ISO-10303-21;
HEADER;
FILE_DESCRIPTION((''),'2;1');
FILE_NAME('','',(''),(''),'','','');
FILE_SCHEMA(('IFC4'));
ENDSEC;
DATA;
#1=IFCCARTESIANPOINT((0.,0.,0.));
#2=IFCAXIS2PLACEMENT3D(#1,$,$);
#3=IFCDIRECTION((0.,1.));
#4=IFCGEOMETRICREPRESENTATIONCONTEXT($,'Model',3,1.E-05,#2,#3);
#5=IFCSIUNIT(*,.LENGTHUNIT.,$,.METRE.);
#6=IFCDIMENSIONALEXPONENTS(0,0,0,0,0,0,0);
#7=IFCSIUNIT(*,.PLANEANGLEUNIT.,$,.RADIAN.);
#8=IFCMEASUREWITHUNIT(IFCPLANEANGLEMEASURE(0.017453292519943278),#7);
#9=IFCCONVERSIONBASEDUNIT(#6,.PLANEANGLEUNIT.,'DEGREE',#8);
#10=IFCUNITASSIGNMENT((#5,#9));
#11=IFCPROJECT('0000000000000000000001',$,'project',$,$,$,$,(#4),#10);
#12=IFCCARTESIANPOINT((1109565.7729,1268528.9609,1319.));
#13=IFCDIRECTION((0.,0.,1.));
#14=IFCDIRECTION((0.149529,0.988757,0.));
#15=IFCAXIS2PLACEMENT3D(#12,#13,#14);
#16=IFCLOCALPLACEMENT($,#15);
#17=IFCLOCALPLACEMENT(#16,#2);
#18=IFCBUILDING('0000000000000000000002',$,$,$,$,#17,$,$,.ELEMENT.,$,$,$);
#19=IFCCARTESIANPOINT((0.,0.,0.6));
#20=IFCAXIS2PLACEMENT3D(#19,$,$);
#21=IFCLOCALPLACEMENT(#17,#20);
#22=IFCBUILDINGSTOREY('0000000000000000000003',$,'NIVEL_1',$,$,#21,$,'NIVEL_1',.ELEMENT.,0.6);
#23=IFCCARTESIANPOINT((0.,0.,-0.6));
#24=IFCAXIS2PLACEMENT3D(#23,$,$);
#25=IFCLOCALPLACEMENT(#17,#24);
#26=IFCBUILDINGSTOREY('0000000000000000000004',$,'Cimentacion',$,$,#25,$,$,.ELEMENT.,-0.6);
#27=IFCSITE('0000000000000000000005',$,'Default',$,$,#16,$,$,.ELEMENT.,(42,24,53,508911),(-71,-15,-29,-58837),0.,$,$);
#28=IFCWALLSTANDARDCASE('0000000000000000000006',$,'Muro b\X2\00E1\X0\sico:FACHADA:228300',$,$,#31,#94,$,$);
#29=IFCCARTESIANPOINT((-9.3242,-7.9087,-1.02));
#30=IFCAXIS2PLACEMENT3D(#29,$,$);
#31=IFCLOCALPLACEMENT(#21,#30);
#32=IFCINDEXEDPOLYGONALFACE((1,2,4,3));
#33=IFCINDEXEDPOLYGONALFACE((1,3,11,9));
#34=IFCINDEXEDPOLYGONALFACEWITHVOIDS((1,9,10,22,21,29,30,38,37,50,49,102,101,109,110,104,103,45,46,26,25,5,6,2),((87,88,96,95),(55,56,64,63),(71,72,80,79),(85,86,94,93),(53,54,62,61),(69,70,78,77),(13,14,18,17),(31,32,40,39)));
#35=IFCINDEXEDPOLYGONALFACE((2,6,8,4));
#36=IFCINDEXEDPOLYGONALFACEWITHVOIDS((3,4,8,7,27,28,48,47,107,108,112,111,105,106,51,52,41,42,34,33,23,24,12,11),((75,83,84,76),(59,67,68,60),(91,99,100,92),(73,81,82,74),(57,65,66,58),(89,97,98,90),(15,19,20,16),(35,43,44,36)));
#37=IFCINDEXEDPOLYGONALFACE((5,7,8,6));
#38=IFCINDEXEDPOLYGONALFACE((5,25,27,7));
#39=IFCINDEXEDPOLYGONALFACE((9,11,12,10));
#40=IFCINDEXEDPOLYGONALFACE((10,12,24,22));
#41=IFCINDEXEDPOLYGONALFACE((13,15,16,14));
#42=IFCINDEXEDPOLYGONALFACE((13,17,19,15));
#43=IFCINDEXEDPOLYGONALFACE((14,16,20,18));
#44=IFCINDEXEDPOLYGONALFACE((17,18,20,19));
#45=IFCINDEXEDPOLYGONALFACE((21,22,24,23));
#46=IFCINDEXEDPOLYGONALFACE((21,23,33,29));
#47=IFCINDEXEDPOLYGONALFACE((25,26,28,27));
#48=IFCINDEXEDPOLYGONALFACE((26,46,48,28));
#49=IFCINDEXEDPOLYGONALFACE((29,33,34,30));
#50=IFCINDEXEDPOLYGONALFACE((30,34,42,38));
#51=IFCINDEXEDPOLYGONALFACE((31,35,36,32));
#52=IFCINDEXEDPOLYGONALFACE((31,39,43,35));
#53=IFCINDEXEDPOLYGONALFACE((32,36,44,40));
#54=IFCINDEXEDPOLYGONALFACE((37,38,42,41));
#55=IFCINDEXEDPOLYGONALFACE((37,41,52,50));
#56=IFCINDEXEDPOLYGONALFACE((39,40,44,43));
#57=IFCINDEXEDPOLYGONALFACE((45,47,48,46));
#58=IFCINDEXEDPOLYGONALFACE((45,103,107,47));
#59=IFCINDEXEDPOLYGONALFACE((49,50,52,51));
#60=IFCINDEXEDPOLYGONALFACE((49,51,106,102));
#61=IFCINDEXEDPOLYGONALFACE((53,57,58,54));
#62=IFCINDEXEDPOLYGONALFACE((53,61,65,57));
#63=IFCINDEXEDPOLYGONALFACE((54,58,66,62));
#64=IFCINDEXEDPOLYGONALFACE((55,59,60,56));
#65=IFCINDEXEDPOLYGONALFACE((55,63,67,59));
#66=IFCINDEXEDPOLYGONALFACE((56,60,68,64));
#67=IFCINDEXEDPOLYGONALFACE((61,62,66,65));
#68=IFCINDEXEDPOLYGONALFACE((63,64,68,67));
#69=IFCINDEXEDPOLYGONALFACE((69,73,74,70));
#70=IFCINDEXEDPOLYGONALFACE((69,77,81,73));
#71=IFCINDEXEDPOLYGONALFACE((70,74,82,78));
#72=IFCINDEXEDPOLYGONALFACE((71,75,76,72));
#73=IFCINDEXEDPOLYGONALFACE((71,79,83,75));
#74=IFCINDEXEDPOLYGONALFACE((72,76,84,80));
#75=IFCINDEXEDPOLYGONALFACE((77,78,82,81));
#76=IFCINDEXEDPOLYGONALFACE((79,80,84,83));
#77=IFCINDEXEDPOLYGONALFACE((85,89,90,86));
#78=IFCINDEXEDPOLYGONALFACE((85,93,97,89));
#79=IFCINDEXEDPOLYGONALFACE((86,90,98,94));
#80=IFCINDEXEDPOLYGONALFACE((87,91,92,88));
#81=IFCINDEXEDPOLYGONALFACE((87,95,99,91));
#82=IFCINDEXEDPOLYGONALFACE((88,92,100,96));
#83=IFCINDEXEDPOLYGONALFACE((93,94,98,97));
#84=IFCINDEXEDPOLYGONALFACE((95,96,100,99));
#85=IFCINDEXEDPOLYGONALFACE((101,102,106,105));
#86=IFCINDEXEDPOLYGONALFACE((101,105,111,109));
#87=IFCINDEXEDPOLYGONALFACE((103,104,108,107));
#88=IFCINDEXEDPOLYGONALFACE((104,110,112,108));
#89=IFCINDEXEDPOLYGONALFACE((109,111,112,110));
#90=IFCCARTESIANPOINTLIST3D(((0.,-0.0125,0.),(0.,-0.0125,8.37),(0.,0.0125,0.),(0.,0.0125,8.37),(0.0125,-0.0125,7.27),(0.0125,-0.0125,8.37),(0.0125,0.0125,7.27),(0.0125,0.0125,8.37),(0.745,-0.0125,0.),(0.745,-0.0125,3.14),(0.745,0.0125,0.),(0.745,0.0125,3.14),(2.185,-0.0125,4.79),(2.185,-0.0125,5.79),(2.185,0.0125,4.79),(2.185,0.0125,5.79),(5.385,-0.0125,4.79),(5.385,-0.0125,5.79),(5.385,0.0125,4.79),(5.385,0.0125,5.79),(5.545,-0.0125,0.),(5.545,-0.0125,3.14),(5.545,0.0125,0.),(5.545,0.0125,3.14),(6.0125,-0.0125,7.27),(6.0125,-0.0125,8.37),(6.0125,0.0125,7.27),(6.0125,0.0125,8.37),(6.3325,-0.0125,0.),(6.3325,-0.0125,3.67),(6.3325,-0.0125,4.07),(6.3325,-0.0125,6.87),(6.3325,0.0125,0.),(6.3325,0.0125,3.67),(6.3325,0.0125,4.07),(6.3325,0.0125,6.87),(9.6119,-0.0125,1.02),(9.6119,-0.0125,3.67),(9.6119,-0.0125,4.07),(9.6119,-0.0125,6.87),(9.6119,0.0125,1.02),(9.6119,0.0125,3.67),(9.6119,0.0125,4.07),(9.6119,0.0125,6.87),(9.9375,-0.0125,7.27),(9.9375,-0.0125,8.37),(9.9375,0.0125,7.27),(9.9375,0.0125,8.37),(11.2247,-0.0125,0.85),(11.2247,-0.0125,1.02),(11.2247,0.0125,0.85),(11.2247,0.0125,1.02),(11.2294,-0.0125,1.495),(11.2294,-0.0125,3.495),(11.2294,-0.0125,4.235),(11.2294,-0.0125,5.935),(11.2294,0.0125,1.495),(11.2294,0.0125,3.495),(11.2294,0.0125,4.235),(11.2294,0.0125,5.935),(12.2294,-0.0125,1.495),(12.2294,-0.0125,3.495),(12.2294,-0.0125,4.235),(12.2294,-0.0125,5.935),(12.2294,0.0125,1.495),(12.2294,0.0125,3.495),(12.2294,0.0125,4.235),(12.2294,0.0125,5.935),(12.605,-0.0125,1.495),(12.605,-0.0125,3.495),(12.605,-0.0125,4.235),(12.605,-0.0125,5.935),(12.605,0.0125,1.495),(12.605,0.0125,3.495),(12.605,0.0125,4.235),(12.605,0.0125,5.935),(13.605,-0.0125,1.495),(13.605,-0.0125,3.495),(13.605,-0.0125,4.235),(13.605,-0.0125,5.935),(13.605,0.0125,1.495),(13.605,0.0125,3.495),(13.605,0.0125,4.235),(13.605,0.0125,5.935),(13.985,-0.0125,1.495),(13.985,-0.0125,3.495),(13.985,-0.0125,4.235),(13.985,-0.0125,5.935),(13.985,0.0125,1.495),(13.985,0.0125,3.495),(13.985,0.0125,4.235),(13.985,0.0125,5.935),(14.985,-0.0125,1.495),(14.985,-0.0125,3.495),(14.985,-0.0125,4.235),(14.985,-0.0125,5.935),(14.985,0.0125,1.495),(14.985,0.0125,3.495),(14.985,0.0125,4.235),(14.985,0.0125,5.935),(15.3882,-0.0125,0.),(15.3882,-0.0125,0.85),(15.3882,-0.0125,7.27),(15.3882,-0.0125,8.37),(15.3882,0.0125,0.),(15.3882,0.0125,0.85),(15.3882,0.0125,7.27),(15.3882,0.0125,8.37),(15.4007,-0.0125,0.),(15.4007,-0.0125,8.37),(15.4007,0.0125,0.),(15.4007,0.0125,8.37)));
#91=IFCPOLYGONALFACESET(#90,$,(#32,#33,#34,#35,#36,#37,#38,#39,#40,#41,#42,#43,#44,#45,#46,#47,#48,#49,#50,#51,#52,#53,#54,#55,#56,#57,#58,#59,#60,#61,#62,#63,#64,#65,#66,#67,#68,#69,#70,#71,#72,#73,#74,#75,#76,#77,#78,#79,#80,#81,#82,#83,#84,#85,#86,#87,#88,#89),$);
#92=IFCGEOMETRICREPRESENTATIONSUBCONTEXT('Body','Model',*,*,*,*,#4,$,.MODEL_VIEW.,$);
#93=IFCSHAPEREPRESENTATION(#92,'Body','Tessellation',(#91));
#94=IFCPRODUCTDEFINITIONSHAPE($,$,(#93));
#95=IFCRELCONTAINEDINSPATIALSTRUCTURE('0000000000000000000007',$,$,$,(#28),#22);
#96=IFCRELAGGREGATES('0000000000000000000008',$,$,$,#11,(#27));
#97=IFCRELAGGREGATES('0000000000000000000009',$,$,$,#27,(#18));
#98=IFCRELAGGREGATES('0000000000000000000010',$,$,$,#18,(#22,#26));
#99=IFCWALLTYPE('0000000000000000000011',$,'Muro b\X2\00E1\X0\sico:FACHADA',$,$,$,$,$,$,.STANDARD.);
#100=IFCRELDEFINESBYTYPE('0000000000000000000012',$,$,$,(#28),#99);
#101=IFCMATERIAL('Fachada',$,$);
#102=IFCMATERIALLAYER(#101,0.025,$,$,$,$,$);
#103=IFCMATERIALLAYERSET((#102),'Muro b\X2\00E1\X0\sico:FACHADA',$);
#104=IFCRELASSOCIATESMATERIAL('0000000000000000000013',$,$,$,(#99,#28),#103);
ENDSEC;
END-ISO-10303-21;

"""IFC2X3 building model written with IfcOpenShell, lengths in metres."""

from ifc_helpers import new_model, entity, si_unit, converted_unit, direction, frame, frame_2d, origin, origin_2d_with_axis, place, context, subcontext, project, spatial, polyline, rectangle, outline, extrude, material, layer, layer_set, layer_usage, type_object, element, save


model = new_model("IFC2X3")

# Units and contexts
model_context = context("Model", 3, precision=1e-05, world=origin(), true_north=direction((0.0, 1.0)))
body_context = subcontext(model_context, "Body", "Model", "MODEL_VIEW")
ifc_project = project(units=[si_unit("LENGTHUNIT", "METRE"), converted_unit("PLANEANGLEUNIT", "DEGREE", entity("IfcPlaneAngleMeasure", 0.017453292519943278), si_unit("PLANEANGLEUNIT", "RADIAN"), dimensions=[0, 0, 0, 0, 0, 0, 0])], contexts=[model_context])

# Site, building, storey
site_placement = place(None, frame((1109565.7729, 1268528.9609, 1319.0), z_axis=(0.0, 0.0, 1.0), x_axis=(0.149529, 0.988757, 0.0)))
site = spatial("IfcSite", under=ifc_project, at=site_placement, Name="Default", CompositionType="ELEMENT", RefLatitude=(42, 24, 53, 508911), RefLongitude=(-71, -15, -29, -58837), RefElevation=0.0)
building_placement = place(site_placement, origin())
building = spatial("IfcBuilding", under=site, at=building_placement, CompositionType="ELEMENT")
storey_1_placement = place(building_placement, frame((0.0, 0.0, 0.6)))
storey_1 = spatial("IfcBuildingStorey", under=building, at=storey_1_placement, Name="NIVEL_1", LongName="NIVEL_1", CompositionType="ELEMENT", Elevation=0.6)

# Shared definitions
storey_2_placement = place(building_placement, frame((0.0, 0.0, -0.6)))
storey_2 = spatial("IfcBuildingStorey", under=building, at=storey_2_placement, Name="Cimentacion", CompositionType="ELEMENT", Elevation=-0.6)

# Wall, openings
ifc_material_1 = material(Name="Fachada")
ifc_layer_1 = layer(ifc_material_1, 0.025)
ifc_layer_set_1 = layer_set([ifc_layer_1], Name="Muro básico:FACHADA")
ifc_layer_usage_1 = layer_usage(ifc_layer_set_1, "AXIS2", "POSITIVE", -0.0125)
wall_type_1 = type_object("IfcWallType", Name="Muro básico:FACHADA", PredefinedType="STANDARD", material=ifc_layer_set_1)
wall_1_placement = place(storey_1_placement, frame((-9.3242, -7.9087, -1.02)))
wall_1 = element("IfcWallStandardCase", 1, at=wall_1_placement, inside=storey_1, type_object=wall_type_1, material=ifc_layer_usage_1, Name="Muro básico:FACHADA:228300", context=body_context, shape_type="SweptSolid", body=[
    extrude(rectangle(XDim=15.4007, YDim=0.025, at=frame_2d((7.7004, 0.0), x_axis=(-1.0, 0.0))), origin(), (0.0, 0.0, 1.0), 8.37),
])
opening_1_placement = place(wall_1_placement, origin())
element("IfcOpeningElement", 2, at=opening_1_placement, cuts=wall_1, ObjectType="Opening", context=body_context, shape_type="SweptSolid", body=[
    extrude(rectangle(XDim=2.8, YDim=3.2794, at=frame_2d((0.0, 0.0), x_axis=(0.0, 1.0))), frame((7.9722, 0.0125, 5.47), z_axis=(0.0, -1.0, 0.0), x_axis=(-1.0, 0.0, 0.0)), (0.0, 0.0, 1.0), 0.025),
])
opening_2_placement = place(wall_1_placement, origin())
element("IfcOpeningElement", 3, at=opening_2_placement, cuts=wall_1, ObjectType="Opening", context=body_context, shape_type="SweptSolid", body=[
    extrude(rectangle(XDim=1.0, YDim=3.2, at=frame_2d((0.0, 0.0), x_axis=(0.0, 1.0))), frame((3.785, 0.0125, 5.29), z_axis=(0.0, -1.0, 0.0), x_axis=(-1.0, 0.0, 0.0)), (0.0, 0.0, 1.0), 0.025),
])
opening_3_placement = place(wall_1_placement, origin())
element("IfcOpeningElement", 4, at=opening_3_placement, cuts=wall_1, ObjectType="Opening", context=body_context, shape_type="SweptSolid", body=[
    extrude(rectangle(XDim=1.7, YDim=1.0, at=frame_2d((0.0, 0.0), x_axis=(0.0, 1.0))), frame((11.7294, 0.0125, 5.085), z_axis=(0.0, -1.0, 0.0), x_axis=(-1.0, 0.0, 0.0)), (0.0, 0.0, 1.0), 0.025),
])
opening_4_placement = place(wall_1_placement, origin())
element("IfcOpeningElement", 5, at=opening_4_placement, cuts=wall_1, ObjectType="Opening", context=body_context, shape_type="SweptSolid", body=[
    extrude(rectangle(XDim=1.7, YDim=1.0, at=origin_2d_with_axis()), frame((13.105, 0.0125, 5.085), z_axis=(0.0, -1.0, 0.0), x_axis=(0.0, 0.0, 1.0)), (0.0, 0.0, 1.0), 0.025),
])
opening_5_placement = place(wall_1_placement, origin())
element("IfcOpeningElement", 6, at=opening_5_placement, cuts=wall_1, ObjectType="Opening", context=body_context, shape_type="SweptSolid", body=[
    extrude(rectangle(XDim=1.7, YDim=1.0, at=origin_2d_with_axis()), frame((14.485, 0.0125, 5.085), z_axis=(0.0, -1.0, 0.0), x_axis=(0.0, 0.0, 1.0)), (0.0, 0.0, 1.0), 0.025),
])
opening_6_placement = place(wall_1_placement, origin())
element("IfcOpeningElement", 7, at=opening_6_placement, cuts=wall_1, ObjectType="Opening", context=body_context, shape_type="SweptSolid", body=[
    extrude(rectangle(XDim=2.0, YDim=1.0, at=origin_2d_with_axis()), frame((14.485, 0.0125, 2.495), z_axis=(0.0, -1.0, 0.0), x_axis=(0.0, 0.0, 1.0)), (0.0, 0.0, 1.0), 0.025),
])
opening_7_placement = place(wall_1_placement, origin())
element("IfcOpeningElement", 8, at=opening_7_placement, cuts=wall_1, ObjectType="Opening", context=body_context, shape_type="SweptSolid", body=[
    extrude(rectangle(XDim=2.0, YDim=1.0, at=origin_2d_with_axis()), frame((13.105, 0.0125, 2.495), z_axis=(0.0, -1.0, 0.0), x_axis=(0.0, 0.0, 1.0)), (0.0, 0.0, 1.0), 0.025),
])
opening_8_placement = place(wall_1_placement, origin())
element("IfcOpeningElement", 9, at=opening_8_placement, cuts=wall_1, ObjectType="Opening", context=body_context, shape_type="SweptSolid", body=[
    extrude(rectangle(XDim=2.0, YDim=1.0, at=frame_2d((0.0, 0.0), x_axis=(1.0, 0.0))), frame((11.7294, 0.0125, 2.495), z_axis=(0.0, -1.0, 0.0), x_axis=(0.0, 0.0, 1.0)), (0.0, 0.0, 1.0), 0.025),
])
opening_9_placement = place(wall_1_placement, origin())
element("IfcOpeningElement", 10, at=opening_9_placement, cuts=wall_1, ObjectType="Opening", context=body_context, shape_type="SweptSolid", body=[
    extrude(rectangle(XDim=3.14, YDim=4.8, at=frame_2d((0.0, 0.0), x_axis=(0.0, 1.0))), frame((3.145, 0.0125, 1.57), z_axis=(0.0, -1.0, 0.0), x_axis=(1.0, 0.0, 0.0)), (0.0, 0.0, 1.0), 0.025),
])
opening_10_placement = place(wall_1_placement, origin())
element("IfcOpeningElement", 11, at=opening_10_placement, cuts=wall_1, ObjectType="Opening", context=body_context, shape_type="SweptSolid", body=[
    extrude(outline(polyline([(-4.3068, -1.385), (4.7489, -1.385), (4.7489, -0.535), (0.5854, -0.535), (0.5854, -0.365), (-1.0274, -0.365), (-1.0274, 2.285), (-4.3068, 2.285), (-4.3068, -1.385)])), frame((10.6393, 0.0125, 1.385), z_axis=(0.0, -1.0, 0.0), x_axis=(1.0, 0.0, 0.0)), (0.0, 0.0, 1.0), 0.025),
])
opening_11_placement = place(wall_1_placement, origin())
element("IfcOpeningElement", 12, at=opening_11_placement, cuts=wall_1, ObjectType="Opening", context=body_context, shape_type="SweptSolid", body=[
    extrude(rectangle(XDim=1.1, YDim=5.4508, at=origin_2d_with_axis()), frame((12.6629, 0.0125, 7.82), z_axis=(0.0, -1.0, 0.0), x_axis=(0.0, 0.0, 1.0)), (0.0, 0.0, 1.0), 0.025),
])
opening_12_placement = place(wall_1_placement, origin())
element("IfcOpeningElement", 13, at=opening_12_placement, cuts=wall_1, ObjectType="Opening", context=body_context, shape_type="SweptSolid", body=[
    extrude(rectangle(XDim=1.1, YDim=6.0, at=frame_2d((0.0, 0.0), x_axis=(0.0, 1.0))), frame((3.0125, 0.0125, 7.82), z_axis=(0.0, -1.0, 0.0), x_axis=(-1.0, 0.0, 0.0)), (0.0, 0.0, 1.0), 0.025),
])

save(model, "model.ifc")
